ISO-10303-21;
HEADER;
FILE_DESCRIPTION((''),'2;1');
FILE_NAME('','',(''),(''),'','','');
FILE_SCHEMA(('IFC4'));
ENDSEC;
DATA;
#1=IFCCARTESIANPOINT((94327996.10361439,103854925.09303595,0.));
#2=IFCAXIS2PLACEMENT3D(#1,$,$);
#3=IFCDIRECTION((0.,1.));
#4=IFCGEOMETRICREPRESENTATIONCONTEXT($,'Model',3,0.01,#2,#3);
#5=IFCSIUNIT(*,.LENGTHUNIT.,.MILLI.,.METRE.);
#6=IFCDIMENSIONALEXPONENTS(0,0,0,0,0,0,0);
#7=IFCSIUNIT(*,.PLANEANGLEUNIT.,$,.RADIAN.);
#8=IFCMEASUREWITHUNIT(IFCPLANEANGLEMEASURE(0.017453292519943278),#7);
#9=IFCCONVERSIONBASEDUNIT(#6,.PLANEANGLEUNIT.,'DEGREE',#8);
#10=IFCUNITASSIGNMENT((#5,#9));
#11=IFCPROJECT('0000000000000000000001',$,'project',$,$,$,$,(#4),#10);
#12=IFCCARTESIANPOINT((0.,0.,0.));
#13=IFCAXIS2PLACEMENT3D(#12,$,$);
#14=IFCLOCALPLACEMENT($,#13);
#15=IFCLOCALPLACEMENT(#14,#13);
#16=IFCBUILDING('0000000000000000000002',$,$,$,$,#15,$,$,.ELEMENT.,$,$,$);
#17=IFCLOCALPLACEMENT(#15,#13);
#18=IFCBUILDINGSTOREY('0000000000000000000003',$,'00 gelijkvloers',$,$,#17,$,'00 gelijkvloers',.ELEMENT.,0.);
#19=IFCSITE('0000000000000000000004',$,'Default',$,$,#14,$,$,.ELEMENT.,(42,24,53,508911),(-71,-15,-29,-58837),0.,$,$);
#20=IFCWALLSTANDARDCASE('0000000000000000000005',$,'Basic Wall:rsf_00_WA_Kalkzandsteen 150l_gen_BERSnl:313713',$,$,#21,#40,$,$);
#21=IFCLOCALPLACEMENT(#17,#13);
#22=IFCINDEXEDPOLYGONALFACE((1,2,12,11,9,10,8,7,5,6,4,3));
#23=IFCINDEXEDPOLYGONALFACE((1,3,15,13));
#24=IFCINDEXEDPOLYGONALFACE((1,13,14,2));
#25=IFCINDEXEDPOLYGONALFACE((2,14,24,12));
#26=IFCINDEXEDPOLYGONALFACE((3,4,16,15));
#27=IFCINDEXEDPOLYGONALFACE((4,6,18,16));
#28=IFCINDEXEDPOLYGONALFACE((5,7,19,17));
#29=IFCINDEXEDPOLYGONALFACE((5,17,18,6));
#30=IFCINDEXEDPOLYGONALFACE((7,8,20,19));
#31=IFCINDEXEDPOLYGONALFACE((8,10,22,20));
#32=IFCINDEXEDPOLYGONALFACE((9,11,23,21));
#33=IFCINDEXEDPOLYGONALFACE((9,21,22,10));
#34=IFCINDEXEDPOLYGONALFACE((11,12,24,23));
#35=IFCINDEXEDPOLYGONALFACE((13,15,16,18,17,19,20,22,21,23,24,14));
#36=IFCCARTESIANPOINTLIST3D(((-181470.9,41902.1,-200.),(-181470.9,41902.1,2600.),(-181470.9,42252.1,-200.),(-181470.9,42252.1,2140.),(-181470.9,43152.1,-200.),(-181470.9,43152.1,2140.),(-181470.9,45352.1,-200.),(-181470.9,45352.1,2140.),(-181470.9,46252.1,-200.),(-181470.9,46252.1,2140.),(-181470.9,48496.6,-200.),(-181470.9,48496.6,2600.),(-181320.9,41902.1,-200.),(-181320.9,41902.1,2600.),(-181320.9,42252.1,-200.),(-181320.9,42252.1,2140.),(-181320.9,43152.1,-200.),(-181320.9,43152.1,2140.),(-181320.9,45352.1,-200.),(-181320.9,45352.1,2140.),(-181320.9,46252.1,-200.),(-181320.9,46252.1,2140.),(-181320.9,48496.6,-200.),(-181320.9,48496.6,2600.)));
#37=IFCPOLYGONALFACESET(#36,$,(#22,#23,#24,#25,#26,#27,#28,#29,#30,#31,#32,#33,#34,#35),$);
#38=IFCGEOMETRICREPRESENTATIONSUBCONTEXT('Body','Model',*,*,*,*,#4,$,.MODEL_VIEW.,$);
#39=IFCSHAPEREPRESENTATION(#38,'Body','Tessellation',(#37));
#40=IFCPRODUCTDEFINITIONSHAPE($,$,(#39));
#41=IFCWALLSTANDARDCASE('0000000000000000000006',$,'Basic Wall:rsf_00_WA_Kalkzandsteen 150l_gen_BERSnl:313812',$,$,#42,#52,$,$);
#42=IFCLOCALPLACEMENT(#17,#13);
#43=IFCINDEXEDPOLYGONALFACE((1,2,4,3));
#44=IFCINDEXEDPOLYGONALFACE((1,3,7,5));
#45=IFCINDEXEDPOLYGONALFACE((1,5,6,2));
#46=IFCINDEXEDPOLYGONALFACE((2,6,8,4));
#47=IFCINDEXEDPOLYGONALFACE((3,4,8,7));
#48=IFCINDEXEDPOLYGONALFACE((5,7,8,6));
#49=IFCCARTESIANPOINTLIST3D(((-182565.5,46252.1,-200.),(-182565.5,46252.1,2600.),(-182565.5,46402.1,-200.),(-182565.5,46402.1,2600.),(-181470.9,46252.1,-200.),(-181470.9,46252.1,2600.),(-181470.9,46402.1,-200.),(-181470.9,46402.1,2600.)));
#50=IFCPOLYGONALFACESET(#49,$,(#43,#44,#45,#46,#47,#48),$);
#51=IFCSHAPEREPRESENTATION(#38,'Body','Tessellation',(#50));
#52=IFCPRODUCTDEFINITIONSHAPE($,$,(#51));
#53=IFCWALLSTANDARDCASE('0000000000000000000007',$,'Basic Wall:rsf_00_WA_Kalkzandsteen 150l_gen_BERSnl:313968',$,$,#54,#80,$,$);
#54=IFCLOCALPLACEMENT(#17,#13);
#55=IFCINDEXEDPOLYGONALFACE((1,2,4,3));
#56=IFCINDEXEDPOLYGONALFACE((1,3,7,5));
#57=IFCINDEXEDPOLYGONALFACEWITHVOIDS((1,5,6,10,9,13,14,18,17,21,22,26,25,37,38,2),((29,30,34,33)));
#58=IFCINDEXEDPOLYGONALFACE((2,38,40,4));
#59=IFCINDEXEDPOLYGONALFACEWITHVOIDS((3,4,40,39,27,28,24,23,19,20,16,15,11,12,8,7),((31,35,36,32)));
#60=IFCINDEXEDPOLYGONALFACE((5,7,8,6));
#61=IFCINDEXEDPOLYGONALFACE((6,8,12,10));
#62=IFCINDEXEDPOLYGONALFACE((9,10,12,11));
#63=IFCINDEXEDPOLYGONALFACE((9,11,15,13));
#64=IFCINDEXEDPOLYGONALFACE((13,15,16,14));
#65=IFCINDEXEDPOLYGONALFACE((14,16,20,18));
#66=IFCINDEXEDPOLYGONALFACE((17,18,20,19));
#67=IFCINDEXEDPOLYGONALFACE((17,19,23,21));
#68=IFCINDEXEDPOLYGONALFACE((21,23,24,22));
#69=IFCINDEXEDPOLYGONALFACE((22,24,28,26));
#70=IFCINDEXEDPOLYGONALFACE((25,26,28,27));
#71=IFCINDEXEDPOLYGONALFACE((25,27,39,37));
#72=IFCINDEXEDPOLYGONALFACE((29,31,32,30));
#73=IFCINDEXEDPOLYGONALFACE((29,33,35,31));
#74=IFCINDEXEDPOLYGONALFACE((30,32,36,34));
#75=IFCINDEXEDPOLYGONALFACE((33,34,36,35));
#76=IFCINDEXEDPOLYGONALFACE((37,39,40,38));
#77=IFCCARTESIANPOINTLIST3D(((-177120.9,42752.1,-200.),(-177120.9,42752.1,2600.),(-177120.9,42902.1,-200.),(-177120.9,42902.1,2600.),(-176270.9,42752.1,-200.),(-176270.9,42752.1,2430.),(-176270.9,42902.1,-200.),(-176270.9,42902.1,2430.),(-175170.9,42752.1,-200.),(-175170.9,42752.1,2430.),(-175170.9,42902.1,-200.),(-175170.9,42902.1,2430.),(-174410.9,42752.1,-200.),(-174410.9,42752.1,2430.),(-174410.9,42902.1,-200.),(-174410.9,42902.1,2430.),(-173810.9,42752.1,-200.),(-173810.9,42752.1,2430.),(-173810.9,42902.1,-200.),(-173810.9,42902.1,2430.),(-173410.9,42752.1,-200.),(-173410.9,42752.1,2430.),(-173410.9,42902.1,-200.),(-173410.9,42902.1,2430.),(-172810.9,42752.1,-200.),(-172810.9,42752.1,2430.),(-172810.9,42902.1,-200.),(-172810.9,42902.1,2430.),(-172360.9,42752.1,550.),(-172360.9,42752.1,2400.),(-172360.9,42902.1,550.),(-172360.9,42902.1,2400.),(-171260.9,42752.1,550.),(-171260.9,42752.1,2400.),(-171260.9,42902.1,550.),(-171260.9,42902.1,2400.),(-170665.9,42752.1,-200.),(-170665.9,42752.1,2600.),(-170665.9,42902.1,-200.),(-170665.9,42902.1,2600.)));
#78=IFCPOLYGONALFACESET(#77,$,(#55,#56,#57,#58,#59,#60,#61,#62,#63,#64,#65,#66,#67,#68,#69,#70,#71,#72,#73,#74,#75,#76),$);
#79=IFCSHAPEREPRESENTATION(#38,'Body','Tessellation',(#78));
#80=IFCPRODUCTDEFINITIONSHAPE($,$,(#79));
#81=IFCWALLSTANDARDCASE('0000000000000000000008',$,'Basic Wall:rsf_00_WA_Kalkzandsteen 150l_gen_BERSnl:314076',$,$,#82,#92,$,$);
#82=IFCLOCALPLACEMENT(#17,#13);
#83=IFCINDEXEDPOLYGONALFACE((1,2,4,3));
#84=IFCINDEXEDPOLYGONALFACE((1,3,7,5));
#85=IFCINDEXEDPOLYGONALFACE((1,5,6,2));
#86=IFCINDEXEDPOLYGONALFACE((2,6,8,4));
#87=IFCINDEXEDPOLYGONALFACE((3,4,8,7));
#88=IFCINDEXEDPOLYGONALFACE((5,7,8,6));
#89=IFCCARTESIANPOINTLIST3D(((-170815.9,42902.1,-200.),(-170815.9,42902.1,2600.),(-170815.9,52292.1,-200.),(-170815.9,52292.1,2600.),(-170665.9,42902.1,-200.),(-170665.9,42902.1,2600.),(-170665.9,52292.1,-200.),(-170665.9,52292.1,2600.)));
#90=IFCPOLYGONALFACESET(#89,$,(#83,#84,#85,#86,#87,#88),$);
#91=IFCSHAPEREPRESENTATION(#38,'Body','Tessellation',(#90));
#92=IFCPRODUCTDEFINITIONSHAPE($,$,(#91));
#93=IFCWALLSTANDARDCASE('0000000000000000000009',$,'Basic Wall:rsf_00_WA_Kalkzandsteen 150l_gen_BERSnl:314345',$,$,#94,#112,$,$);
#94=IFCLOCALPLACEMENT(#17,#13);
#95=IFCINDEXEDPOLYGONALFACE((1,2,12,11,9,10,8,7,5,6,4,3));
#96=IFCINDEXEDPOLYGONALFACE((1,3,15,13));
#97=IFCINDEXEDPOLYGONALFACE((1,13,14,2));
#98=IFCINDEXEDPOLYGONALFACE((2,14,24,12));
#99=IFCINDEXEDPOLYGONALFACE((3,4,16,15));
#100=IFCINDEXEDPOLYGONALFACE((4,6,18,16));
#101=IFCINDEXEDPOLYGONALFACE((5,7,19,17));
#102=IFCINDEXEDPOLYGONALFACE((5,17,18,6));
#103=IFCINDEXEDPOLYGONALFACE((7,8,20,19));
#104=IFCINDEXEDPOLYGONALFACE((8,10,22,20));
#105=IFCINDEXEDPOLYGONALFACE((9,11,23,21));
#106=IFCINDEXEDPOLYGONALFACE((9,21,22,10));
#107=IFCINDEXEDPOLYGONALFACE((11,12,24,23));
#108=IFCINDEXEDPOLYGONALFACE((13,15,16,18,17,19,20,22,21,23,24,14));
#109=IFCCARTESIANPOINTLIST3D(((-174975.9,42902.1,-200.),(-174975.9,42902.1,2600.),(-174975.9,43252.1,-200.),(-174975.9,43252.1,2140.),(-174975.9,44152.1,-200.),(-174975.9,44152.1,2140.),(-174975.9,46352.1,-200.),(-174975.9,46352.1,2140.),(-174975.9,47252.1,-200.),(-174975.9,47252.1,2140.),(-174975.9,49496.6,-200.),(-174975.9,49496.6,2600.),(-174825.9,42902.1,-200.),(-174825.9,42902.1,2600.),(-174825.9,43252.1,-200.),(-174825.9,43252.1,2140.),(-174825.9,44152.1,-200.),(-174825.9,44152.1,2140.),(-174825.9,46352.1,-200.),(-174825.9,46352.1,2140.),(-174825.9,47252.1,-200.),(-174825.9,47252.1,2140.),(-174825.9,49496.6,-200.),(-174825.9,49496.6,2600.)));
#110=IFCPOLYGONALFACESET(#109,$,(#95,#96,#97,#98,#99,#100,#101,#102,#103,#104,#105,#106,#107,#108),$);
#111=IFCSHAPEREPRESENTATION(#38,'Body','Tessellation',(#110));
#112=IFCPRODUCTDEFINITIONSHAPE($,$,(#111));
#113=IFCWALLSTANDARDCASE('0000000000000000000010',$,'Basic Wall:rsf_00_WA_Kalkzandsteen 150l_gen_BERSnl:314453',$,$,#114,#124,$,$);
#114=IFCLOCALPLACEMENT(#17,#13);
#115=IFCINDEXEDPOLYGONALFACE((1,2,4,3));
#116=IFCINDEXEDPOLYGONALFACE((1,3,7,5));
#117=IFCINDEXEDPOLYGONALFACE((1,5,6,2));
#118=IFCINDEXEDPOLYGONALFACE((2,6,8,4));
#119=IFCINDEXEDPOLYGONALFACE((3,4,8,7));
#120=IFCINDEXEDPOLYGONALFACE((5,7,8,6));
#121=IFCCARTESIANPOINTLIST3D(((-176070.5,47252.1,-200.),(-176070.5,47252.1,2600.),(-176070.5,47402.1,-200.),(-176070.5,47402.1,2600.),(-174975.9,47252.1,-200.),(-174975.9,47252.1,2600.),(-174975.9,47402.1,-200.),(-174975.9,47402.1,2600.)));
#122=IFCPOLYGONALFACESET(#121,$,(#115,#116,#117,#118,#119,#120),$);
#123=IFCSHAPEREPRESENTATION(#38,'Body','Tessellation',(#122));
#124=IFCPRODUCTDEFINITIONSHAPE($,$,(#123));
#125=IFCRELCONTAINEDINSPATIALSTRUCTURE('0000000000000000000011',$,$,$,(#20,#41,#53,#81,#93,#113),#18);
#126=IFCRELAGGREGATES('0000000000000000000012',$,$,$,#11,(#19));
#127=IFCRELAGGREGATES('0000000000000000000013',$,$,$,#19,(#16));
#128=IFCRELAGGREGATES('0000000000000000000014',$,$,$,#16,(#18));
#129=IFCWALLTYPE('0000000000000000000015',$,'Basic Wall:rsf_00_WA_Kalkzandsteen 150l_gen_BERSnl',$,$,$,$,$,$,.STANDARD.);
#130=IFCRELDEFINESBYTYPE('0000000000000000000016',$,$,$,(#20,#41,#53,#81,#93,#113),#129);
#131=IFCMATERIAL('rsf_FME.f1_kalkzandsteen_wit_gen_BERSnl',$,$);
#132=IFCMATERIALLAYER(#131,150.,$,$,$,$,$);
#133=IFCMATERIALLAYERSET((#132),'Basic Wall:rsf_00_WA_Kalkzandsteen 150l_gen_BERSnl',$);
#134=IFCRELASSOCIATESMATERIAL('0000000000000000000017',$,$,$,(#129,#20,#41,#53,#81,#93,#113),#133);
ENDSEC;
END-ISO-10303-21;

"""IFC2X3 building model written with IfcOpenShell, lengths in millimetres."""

from ifc_helpers import new_model, entity, si_unit, converted_unit, direction, frame, frame_2d, origin, origin_2d_with_axis, place, context, subcontext, project, spatial, polyline, rectangle, extrude, clip, bounded_halfspace, material, layer, layer_set, layer_usage, type_object, element, save


model = new_model("IFC2X3")

# Units and contexts
model_context = context("Model", 3, precision=0.01, world=frame((94327996.10361439, 103854925.09303595, 0.0)), true_north=direction((0.0, 1.0)))
body_context = subcontext(model_context, "Body", "Model", "MODEL_VIEW")
ifc_project = project(units=[si_unit("LENGTHUNIT", "METRE", prefix="MILLI"), converted_unit("PLANEANGLEUNIT", "DEGREE", entity("IfcPlaneAngleMeasure", 0.017453292519943278), si_unit("PLANEANGLEUNIT", "RADIAN"), dimensions=[0, 0, 0, 0, 0, 0, 0])], contexts=[model_context])

# Site, building, storey
site_placement = place(None, origin())
site = spatial("IfcSite", under=ifc_project, at=site_placement, Name="Default", CompositionType="ELEMENT", RefLatitude=(42, 24, 53, 508911), RefLongitude=(-71, -15, -29, -58837), RefElevation=0.0)
building_placement = place(site_placement, origin())
building = spatial("IfcBuilding", under=site, at=building_placement, CompositionType="ELEMENT")
storey_placement = place(building_placement, origin())
storey = spatial("IfcBuildingStorey", under=building, at=storey_placement, Name="00 gelijkvloers", LongName="00 gelijkvloers", CompositionType="ELEMENT", Elevation=0.0)

# Shared definitions
ifc_material_1 = material(Name="rsf_FME.f1_kalkzandsteen_wit_gen_BERSnl")
ifc_layer_1 = layer(ifc_material_1, 150.0)
ifc_layer_set_1 = layer_set([ifc_layer_1], Name="Basic Wall:rsf_00_WA_Kalkzandsteen 150l_gen_BERSnl")
wall_type_1 = type_object("IfcWallType", Name="Basic Wall:rsf_00_WA_Kalkzandsteen 150l_gen_BERSnl", PredefinedType="STANDARD", material=ifc_layer_set_1)

# Wall, openings
ifc_layer_usage_1 = layer_usage(ifc_layer_set_1, "AXIS2", "POSITIVE", -75.0)
wall_1_placement = place(storey_placement, frame((-181395.9, 41902.1, -200.0), z_axis=(0.0, 0.0, 1.0), x_axis=(0.0, 1.0, 0.0)))
wall_1 = element("IfcWallStandardCase", 1, at=wall_1_placement, inside=storey, type_object=wall_type_1, material=ifc_layer_usage_1, Name="Basic Wall:rsf_00_WA_Kalkzandsteen 150l_gen_BERSnl:313713", context=body_context, shape_type="Clipping", body=[
    clip(extrude(rectangle(XDim=6594.5, YDim=150.0, at=frame_2d((3297.3, 0.0), x_axis=(1.0, 0.0))), origin(), (0.0, 0.0, 1.0), 2800.0), bounded_halfspace(frame((0.0, -75.0, 2800.0), z_axis=(0.0, 0.0, -1.0), x_axis=(0.0, -1.0, 0.0)), True, frame((0.0, -75.0, 2800.0)), polyline([(0.0, 0.0), (6594.5, 0.0), (6594.5, 150.0), (4500.0, 150.0), (4350.0, 150.0), (0.0, 150.0), (0.0, 0.0)]))),
])
opening_1_placement = place(wall_1_placement, frame((-41902.1, -181395.9, 200.0), z_axis=(0.0, 0.0, 1.0), x_axis=(0.0, -1.0, 0.0)))
element("IfcOpeningElement", 2, at=opening_1_placement, cuts=wall_1, ObjectType="Opening", context=body_context, shape_type="SweptSolid", body=[
    extrude(rectangle(XDim=2340.0, YDim=900.0, at=origin_2d_with_axis()), frame((-179946.9, 42702.1, 970.0), z_axis=(-1.0, 0.0, 0.0), x_axis=(0.0, 0.0, 1.0)), (0.0, 0.0, 1.0), 3048.0),
])
opening_2_placement = place(wall_1_placement, frame((-41902.1, -181395.9, 200.0), z_axis=(0.0, 0.0, 1.0), x_axis=(0.0, -1.0, 0.0)))
element("IfcOpeningElement", 3, at=opening_2_placement, cuts=wall_1, ObjectType="Opening", context=body_context, shape_type="SweptSolid", body=[
    extrude(rectangle(XDim=2340.0, YDim=900.0, at=frame_2d((0.0, 0.0), x_axis=(0.0, 1.0))), frame((-179796.9, 45802.1, 970.0), z_axis=(-1.0, 0.0, 0.0), x_axis=(0.0, -1.0, 0.0)), (0.0, 0.0, 1.0), 3048.0),
])

# Wall
ifc_layer_usage_2 = layer_usage(ifc_layer_set_1, "AXIS2", "POSITIVE", -75.0)
wall_2_placement = place(storey_placement, frame((-181470.9, 46327.1, -200.0), z_axis=(0.0, 0.0, 1.0), x_axis=(-1.0, 0.0, 0.0)))
element("IfcWallStandardCase", 4, at=wall_2_placement, inside=storey, type_object=wall_type_1, material=ifc_layer_usage_2, Name="Basic Wall:rsf_00_WA_Kalkzandsteen 150l_gen_BERSnl:313812", context=body_context, shape_type="Clipping", body=[
    clip(extrude(rectangle(XDim=1094.6, YDim=150.0, at=frame_2d((547.3, 0.0), x_axis=(-1.0, 0.0))), origin(), (0.0, 0.0, 1.0), 2800.0), bounded_halfspace(frame((0.0, -75.0, 2800.0), z_axis=(0.0, 0.0, -1.0), x_axis=(-1.0, 0.0, 0.0)), True, frame((0.0, -75.0, 2800.0)), polyline([(0.0, 0.0), (1094.6, 0.0), (1094.6, 150.0), (0.0, 150.0), (0.0, 0.0)]))),
])

# Wall, openings
ifc_layer_usage_3 = layer_usage(ifc_layer_set_1, "AXIS2", "NEGATIVE", 75.0)
wall_3_placement = place(storey_placement, frame((-177120.9, 42827.1, -200.0)))
wall_3 = element("IfcWallStandardCase", 5, at=wall_3_placement, inside=storey, type_object=wall_type_1, material=ifc_layer_usage_3, Name="Basic Wall:rsf_00_WA_Kalkzandsteen 150l_gen_BERSnl:313968", context=body_context, shape_type="Clipping", body=[
    clip(extrude(rectangle(XDim=6455.0, YDim=150.0, at=frame_2d((3227.5, 0.0), x_axis=(-1.0, 0.0))), origin(), (0.0, 0.0, 1.0), 2800.0), bounded_halfspace(frame((0.0, -75.0, 2800.0), z_axis=(0.0, 0.0, -1.0), x_axis=(1.0, 0.0, 0.0)), True, frame((0.0, -75.0, 2800.0)), polyline([(0.0, 0.0), (6455.0, 0.0), (6455.0, 150.0), (6305.0, 150.0), (2295.0, 150.0), (2145.0, 150.0), (150.0, 150.0), (0.0, 150.0), (0.0, 0.0)]))),
])
opening_3_placement = place(wall_3_placement, frame((177120.9, -42827.1, 200.0)))
element("IfcOpeningElement", 6, at=opening_3_placement, cuts=wall_3, ObjectType="Opening", context=body_context, shape_type="SweptSolid", body=[
    extrude(rectangle(XDim=2630.0, YDim=1100.0, at=frame_2d((0.0, 0.0), x_axis=(1.0, 0.0))), frame((-175720.9, 41378.1, 1115.0), z_axis=(0.0, 1.0, 0.0), x_axis=(0.0, 0.0, 1.0)), (0.0, 0.0, 1.0), 3048.0),
])
opening_4_placement = place(wall_3_placement, frame((177120.9, -42827.1, 200.0)))
element("IfcOpeningElement", 7, at=opening_4_placement, cuts=wall_3, ObjectType="Opening", context=body_context, shape_type="SweptSolid", body=[
    extrude(rectangle(XDim=2630.0, YDim=600.0, at=frame_2d((0.0, 0.0), x_axis=(0.0, 1.0))), frame((-174110.9, 41228.1, 1115.0), z_axis=(0.0, 1.0, 0.0), x_axis=(-1.0, 0.0, 0.0)), (0.0, 0.0, 1.0), 3048.0),
])
opening_5_placement = place(wall_3_placement, frame((177120.9, -42827.1, 200.0)))
element("IfcOpeningElement", 8, at=opening_5_placement, cuts=wall_3, ObjectType="Opening", context=body_context, shape_type="SweptSolid", body=[
    extrude(rectangle(XDim=2630.0, YDim=600.0, at=origin_2d_with_axis()), frame((-173110.9, 41378.1, 1115.0), z_axis=(0.0, 1.0, 0.0), x_axis=(0.0, 0.0, 1.0)), (0.0, 0.0, 1.0), 3048.0),
])
opening_6_placement = place(wall_3_placement, frame((177120.9, -42827.1, 200.0)))
element("IfcOpeningElement", 9, at=opening_6_placement, cuts=wall_3, ObjectType="Opening", context=body_context, shape_type="SweptSolid", body=[
    extrude(rectangle(XDim=1850.0, YDim=1100.0, at=frame_2d((0.0, 0.0), x_axis=(0.0, 1.0))), frame((-171810.9, 41228.1, 1475.0), z_axis=(0.0, 1.0, 0.0), x_axis=(-1.0, 0.0, 0.0)), (0.0, 0.0, 1.0), 3048.0),
])

# Wall
ifc_layer_usage_4 = layer_usage(ifc_layer_set_1, "AXIS2", "NEGATIVE", 75.0)
wall_4_placement = place(storey_placement, frame((-170740.9, 42902.1, -200.0), z_axis=(0.0, 0.0, 1.0), x_axis=(0.0, 1.0, 0.0)))
element("IfcWallStandardCase", 10, at=wall_4_placement, inside=storey, type_object=wall_type_1, material=ifc_layer_usage_4, Name="Basic Wall:rsf_00_WA_Kalkzandsteen 150l_gen_BERSnl:314076", context=body_context, shape_type="Clipping", body=[
    clip(extrude(rectangle(XDim=9390.0, YDim=150.0, at=frame_2d((4695.0, 0.0), x_axis=(-1.0, 0.0))), origin(), (0.0, 0.0, 1.0), 2800.0), bounded_halfspace(frame((0.0, -75.0, 2800.0), z_axis=(0.0, 0.0, -1.0), x_axis=(0.0, -1.0, 0.0)), True, frame((0.0, -75.0, 2800.0)), polyline([(0.0, 0.0), (9390.0, 0.0), (9390.0, 150.0), (9240.0, 150.0), (0.0, 150.0), (0.0, 0.0)]))),
])

# Wall, openings
ifc_layer_usage_5 = layer_usage(ifc_layer_set_1, "AXIS2", "POSITIVE", -75.0)
wall_5_placement = place(storey_placement, frame((-174900.9, 42902.1, -200.0), z_axis=(0.0, 0.0, 1.0), x_axis=(0.0, 1.0, 0.0)))
wall_5 = element("IfcWallStandardCase", 11, at=wall_5_placement, inside=storey, type_object=wall_type_1, material=ifc_layer_usage_5, Name="Basic Wall:rsf_00_WA_Kalkzandsteen 150l_gen_BERSnl:314345", context=body_context, shape_type="Clipping", body=[
    clip(extrude(rectangle(XDim=6594.5, YDim=150.0, at=frame_2d((3297.3, 0.0), x_axis=(1.0, 0.0))), origin(), (0.0, 0.0, 1.0), 2800.0), bounded_halfspace(frame((0.0, -75.0, 2800.0), z_axis=(0.0, 0.0, -1.0), x_axis=(0.0, -1.0, 0.0)), True, frame((0.0, -75.0, 2800.0)), polyline([(0.0, 0.0), (6594.5, 0.0), (6594.5, 150.0), (4500.0, 150.0), (4350.0, 150.0), (0.0, 150.0), (0.0, 0.0)]))),
])
opening_7_placement = place(wall_5_placement, frame((-42902.1, -174900.9, 200.0), z_axis=(0.0, 0.0, 1.0), x_axis=(0.0, -1.0, 0.0)))
element("IfcOpeningElement", 12, at=opening_7_placement, cuts=wall_5, ObjectType="Opening", context=body_context, shape_type="SweptSolid", body=[
    extrude(rectangle(XDim=2340.0, YDim=900.0, at=origin_2d_with_axis()), frame((-173451.9, 43702.1, 970.0), z_axis=(-1.0, 0.0, 0.0), x_axis=(0.0, 0.0, 1.0)), (0.0, 0.0, 1.0), 3048.0),
])
opening_8_placement = place(wall_5_placement, frame((-42902.1, -174900.9, 200.0), z_axis=(0.0, 0.0, 1.0), x_axis=(0.0, -1.0, 0.0)))
element("IfcOpeningElement", 13, at=opening_8_placement, cuts=wall_5, ObjectType="Opening", context=body_context, shape_type="SweptSolid", body=[
    extrude(rectangle(XDim=2340.0, YDim=900.0, at=origin_2d_with_axis()), frame((-173451.9, 46802.1, 970.0), z_axis=(-1.0, 0.0, 0.0), x_axis=(0.0, 0.0, 1.0)), (0.0, 0.0, 1.0), 3048.0),
])

# Wall
ifc_layer_usage_6 = layer_usage(ifc_layer_set_1, "AXIS2", "POSITIVE", -75.0)
wall_6_placement = place(storey_placement, frame((-174975.9, 47327.1, -200.0), z_axis=(0.0, 0.0, 1.0), x_axis=(-1.0, 0.0, 0.0)))
element("IfcWallStandardCase", 14, at=wall_6_placement, inside=storey, type_object=wall_type_1, material=ifc_layer_usage_6, Name="Basic Wall:rsf_00_WA_Kalkzandsteen 150l_gen_BERSnl:314453", context=body_context, shape_type="Clipping", body=[
    clip(extrude(rectangle(XDim=1094.6, YDim=150.0, at=frame_2d((547.3, 0.0), x_axis=(-1.0, 0.0))), origin(), (0.0, 0.0, 1.0), 2800.0), bounded_halfspace(frame((0.0, -75.0, 2800.0), z_axis=(0.0, 0.0, -1.0), x_axis=(-1.0, 0.0, 0.0)), True, frame((0.0, -75.0, 2800.0)), polyline([(0.0, 0.0), (1094.6, 0.0), (1094.6, 150.0), (0.0, 150.0), (0.0, 0.0)]))),
])

save(model, "model.ifc")
